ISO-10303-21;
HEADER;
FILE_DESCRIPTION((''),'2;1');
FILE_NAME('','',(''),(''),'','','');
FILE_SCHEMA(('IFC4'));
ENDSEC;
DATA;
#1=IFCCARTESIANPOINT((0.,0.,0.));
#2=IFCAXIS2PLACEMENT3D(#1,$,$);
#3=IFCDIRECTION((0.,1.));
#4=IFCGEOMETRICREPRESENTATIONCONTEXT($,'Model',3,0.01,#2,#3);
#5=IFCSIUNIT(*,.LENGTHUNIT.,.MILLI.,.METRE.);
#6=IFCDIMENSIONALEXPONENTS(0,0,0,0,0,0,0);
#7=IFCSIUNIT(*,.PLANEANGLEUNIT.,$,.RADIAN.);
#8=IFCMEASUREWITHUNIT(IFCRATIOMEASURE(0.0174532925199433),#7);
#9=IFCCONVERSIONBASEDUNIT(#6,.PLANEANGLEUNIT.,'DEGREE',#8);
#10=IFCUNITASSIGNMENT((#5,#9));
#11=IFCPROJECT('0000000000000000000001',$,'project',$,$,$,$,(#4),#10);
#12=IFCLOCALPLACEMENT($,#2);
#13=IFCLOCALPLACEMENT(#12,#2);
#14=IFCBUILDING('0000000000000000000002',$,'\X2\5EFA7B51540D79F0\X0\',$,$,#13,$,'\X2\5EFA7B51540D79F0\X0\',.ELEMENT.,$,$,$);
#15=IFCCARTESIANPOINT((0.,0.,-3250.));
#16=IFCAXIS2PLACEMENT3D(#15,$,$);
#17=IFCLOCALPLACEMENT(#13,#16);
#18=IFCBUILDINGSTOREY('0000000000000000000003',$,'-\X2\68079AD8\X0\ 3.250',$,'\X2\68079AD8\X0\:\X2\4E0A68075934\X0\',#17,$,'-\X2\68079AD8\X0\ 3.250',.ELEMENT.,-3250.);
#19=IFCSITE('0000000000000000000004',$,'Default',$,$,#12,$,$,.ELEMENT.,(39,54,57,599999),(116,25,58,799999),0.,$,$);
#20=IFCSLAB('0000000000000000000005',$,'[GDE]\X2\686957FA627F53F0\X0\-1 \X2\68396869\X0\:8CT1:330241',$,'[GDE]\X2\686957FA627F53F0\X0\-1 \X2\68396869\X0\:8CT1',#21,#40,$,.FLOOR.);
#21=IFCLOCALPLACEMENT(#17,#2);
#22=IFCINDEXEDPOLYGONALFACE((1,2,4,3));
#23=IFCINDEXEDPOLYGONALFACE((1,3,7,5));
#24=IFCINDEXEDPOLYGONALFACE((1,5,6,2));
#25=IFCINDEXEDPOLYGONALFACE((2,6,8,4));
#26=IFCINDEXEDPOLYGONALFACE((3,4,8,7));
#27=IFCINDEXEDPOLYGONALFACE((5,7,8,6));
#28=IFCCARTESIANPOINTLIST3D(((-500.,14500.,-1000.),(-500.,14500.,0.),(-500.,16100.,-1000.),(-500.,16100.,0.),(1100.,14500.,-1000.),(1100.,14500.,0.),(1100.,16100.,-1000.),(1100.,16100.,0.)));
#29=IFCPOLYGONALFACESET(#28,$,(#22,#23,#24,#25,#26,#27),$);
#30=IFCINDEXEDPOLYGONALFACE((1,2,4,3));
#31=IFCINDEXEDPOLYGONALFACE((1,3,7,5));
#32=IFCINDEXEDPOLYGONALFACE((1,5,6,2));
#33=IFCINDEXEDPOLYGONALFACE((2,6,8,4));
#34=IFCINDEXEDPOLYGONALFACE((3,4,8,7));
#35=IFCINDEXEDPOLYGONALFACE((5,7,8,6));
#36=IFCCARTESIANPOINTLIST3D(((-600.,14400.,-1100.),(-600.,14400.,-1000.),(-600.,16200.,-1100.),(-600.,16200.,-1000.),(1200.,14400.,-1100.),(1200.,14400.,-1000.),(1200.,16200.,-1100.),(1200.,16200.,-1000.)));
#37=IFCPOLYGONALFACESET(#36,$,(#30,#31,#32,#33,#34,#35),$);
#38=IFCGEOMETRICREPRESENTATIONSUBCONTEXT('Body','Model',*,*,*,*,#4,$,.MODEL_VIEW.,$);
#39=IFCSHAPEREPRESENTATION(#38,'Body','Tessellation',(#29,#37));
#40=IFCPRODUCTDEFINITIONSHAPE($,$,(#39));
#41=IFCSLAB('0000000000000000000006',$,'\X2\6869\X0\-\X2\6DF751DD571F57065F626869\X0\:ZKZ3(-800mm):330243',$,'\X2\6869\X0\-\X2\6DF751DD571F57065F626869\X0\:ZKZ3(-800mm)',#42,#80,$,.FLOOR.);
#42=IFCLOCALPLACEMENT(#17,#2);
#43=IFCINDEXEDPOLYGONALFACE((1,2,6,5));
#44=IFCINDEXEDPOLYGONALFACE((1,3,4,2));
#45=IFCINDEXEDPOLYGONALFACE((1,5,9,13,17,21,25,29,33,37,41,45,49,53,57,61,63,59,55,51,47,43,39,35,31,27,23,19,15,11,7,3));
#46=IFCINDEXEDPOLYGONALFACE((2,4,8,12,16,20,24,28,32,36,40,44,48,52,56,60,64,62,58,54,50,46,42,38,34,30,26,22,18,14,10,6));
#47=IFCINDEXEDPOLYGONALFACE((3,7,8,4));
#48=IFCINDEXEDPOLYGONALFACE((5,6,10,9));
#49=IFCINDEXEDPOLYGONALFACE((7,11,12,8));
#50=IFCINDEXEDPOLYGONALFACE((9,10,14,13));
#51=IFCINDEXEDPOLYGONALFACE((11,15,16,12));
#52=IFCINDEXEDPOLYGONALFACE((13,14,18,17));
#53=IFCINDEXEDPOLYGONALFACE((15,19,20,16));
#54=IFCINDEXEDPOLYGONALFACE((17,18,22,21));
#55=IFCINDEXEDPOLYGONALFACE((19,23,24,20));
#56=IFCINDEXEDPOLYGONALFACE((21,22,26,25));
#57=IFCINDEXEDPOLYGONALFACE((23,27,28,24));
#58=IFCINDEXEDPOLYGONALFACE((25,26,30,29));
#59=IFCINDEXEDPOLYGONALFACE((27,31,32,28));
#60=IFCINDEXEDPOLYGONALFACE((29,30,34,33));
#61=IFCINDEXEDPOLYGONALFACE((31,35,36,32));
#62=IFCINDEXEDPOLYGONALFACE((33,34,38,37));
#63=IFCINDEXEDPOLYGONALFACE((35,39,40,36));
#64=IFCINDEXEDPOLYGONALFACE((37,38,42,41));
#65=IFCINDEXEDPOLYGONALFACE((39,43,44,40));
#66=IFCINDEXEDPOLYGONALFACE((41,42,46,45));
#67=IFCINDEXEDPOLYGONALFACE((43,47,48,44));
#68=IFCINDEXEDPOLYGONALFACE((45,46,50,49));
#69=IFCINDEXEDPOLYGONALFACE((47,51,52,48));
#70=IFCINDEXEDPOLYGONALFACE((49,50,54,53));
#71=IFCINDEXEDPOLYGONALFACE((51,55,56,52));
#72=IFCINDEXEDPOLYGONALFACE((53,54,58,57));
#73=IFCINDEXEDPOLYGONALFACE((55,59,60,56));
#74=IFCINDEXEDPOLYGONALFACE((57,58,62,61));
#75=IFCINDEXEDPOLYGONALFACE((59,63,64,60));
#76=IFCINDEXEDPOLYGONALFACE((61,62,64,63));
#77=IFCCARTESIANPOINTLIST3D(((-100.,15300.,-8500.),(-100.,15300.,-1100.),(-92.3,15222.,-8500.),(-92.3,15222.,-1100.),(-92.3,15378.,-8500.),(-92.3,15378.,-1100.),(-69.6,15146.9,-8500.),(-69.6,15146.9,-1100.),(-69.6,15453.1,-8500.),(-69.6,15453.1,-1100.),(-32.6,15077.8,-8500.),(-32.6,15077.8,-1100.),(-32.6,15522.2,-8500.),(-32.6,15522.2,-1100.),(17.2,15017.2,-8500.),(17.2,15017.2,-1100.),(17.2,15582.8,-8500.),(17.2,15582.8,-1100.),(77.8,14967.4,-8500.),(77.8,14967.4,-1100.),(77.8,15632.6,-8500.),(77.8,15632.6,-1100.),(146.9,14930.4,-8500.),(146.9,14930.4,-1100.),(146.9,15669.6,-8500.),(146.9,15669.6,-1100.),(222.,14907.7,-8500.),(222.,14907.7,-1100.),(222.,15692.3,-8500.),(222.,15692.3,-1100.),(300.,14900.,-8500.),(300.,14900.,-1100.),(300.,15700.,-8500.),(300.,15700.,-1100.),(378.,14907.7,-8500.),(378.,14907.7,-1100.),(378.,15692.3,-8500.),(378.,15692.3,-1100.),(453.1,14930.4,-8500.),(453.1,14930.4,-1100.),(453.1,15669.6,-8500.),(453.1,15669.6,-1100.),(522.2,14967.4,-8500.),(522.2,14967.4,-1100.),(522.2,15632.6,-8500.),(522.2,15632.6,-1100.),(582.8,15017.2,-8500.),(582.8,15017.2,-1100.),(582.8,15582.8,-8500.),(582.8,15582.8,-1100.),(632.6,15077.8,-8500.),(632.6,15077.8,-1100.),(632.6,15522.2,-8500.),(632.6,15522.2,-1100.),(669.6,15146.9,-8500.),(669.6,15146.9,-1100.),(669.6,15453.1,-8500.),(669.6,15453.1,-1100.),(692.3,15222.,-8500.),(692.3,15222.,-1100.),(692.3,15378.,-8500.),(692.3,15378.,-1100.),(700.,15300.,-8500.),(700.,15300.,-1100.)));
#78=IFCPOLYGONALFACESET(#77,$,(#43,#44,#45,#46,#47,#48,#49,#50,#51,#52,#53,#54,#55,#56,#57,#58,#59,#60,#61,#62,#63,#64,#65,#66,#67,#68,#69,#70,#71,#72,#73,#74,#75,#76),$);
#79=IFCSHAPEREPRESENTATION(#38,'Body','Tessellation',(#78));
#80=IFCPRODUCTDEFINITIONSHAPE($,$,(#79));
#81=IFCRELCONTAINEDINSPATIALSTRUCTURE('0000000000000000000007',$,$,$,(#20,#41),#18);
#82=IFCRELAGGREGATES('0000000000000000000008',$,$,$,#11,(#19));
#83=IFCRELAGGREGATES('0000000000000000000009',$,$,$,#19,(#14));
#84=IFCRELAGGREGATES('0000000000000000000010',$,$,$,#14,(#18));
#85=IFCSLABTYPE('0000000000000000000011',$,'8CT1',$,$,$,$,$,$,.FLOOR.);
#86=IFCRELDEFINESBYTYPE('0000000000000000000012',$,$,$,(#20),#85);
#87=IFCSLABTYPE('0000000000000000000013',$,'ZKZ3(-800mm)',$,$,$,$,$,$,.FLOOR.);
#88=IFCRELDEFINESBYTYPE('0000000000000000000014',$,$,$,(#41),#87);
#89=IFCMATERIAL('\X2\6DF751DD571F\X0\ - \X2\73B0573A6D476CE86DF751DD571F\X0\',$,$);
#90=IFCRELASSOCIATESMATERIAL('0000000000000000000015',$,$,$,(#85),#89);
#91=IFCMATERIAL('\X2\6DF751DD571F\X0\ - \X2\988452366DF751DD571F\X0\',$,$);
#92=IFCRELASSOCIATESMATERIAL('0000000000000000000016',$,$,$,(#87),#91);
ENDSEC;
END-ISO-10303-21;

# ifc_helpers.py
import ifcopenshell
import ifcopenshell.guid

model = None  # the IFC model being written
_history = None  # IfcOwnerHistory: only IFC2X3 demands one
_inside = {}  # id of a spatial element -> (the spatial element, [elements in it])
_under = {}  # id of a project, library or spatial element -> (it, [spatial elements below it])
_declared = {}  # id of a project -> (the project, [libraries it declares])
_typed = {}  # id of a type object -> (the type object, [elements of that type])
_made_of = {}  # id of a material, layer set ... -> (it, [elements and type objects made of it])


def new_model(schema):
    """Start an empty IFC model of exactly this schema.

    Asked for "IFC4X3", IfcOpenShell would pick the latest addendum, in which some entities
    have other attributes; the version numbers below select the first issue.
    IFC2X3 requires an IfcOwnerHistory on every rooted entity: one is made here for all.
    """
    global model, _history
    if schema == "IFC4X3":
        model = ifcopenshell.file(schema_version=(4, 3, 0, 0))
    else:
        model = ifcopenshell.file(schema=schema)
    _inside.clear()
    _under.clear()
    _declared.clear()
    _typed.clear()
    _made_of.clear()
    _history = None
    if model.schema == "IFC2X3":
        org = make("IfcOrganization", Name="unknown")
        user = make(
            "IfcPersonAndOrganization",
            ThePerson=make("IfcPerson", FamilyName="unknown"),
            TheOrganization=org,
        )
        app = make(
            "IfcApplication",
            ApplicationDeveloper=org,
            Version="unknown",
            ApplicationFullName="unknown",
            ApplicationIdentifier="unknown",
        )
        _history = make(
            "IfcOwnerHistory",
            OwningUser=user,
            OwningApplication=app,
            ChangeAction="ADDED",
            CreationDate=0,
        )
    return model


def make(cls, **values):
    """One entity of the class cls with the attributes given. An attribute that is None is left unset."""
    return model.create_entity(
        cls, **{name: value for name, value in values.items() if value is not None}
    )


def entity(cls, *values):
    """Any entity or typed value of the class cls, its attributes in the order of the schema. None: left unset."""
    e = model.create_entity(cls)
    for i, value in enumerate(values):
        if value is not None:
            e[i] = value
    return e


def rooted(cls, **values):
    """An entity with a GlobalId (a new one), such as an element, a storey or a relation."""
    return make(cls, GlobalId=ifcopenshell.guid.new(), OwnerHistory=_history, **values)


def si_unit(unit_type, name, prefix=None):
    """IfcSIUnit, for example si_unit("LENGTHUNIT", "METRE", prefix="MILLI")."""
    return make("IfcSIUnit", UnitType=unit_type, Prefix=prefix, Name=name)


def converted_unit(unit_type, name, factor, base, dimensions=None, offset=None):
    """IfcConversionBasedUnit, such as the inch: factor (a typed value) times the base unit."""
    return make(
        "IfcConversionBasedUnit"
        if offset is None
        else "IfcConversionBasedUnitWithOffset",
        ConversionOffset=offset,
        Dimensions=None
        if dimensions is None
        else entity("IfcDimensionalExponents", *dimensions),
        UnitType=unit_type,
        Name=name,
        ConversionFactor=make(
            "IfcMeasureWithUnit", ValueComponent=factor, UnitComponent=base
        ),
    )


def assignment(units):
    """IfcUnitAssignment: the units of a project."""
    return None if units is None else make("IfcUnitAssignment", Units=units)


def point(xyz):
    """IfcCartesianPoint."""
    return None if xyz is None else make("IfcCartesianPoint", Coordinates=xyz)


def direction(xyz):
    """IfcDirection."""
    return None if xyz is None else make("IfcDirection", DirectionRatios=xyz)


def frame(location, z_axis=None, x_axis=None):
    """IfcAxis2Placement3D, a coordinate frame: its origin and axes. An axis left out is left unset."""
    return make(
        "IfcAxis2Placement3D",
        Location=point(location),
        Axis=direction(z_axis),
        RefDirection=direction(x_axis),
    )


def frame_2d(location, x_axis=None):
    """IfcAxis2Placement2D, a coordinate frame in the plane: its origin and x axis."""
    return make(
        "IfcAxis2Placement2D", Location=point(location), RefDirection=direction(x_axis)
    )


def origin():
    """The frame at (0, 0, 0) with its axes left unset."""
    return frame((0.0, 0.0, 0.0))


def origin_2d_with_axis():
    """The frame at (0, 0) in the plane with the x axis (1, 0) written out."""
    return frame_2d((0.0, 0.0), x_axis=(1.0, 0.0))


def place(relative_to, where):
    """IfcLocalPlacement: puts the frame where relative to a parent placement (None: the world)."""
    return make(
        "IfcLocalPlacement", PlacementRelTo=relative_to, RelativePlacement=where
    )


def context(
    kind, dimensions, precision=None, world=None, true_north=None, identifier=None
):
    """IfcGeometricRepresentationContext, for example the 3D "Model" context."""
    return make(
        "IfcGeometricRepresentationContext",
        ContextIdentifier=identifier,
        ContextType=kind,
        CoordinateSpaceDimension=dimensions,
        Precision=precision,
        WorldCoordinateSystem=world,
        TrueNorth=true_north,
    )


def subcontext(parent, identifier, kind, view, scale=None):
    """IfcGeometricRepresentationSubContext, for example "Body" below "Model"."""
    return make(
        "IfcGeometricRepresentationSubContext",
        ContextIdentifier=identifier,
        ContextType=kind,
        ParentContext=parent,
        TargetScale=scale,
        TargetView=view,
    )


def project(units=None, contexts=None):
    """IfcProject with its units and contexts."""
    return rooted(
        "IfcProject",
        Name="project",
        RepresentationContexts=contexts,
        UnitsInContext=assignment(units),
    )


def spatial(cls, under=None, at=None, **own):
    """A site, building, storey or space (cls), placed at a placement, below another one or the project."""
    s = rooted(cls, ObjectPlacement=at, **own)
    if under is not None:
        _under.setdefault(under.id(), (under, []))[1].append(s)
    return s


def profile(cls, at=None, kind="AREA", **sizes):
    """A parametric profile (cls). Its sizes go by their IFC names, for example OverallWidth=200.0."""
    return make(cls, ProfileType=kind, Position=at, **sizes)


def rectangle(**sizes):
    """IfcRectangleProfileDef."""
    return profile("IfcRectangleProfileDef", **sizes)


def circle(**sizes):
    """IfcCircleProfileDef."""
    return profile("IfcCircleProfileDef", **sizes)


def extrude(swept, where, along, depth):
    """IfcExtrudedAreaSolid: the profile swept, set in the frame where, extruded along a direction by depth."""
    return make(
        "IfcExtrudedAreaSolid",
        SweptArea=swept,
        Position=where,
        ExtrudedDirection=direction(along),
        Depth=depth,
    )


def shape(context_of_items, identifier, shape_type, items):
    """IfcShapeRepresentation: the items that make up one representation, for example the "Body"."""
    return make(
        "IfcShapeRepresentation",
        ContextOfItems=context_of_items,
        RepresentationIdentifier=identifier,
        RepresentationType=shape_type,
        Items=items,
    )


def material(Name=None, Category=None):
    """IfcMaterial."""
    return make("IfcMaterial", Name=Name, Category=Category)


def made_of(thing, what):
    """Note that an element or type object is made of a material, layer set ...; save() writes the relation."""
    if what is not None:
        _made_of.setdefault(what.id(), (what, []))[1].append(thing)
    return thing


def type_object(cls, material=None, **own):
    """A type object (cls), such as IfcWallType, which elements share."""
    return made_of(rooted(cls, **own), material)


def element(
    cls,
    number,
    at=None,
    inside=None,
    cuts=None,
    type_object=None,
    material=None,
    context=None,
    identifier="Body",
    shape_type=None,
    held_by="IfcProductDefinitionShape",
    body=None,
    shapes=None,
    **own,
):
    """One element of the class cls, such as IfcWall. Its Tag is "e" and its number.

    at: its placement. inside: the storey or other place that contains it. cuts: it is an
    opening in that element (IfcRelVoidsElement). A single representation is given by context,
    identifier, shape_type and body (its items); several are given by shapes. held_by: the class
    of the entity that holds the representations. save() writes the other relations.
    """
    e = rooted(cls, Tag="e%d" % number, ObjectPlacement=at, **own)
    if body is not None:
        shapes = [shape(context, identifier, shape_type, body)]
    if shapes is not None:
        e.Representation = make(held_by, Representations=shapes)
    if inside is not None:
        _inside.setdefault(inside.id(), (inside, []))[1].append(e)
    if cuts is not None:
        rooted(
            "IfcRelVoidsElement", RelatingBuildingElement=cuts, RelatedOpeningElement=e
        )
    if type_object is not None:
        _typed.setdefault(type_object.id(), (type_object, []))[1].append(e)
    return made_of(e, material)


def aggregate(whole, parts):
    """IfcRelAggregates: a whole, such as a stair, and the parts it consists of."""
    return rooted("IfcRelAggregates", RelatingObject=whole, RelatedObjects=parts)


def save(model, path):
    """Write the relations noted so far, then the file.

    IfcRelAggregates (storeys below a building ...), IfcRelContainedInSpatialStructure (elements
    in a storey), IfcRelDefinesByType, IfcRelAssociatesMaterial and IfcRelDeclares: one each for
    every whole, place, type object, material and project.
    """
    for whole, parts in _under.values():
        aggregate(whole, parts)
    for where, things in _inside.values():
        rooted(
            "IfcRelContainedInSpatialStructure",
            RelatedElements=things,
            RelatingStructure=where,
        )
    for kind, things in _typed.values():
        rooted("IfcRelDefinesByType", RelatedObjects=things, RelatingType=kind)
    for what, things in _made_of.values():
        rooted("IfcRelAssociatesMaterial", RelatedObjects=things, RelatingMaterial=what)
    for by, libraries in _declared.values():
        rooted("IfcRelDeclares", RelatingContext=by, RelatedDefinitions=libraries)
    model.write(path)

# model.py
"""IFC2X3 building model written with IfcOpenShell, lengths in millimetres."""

from ifc_helpers import new_model, entity, si_unit, converted_unit, direction, frame, frame_2d, origin, origin_2d_with_axis, place, context, subcontext, project, spatial, rectangle, circle, extrude, material, type_object, element, save


model = new_model("IFC2X3")

# Units and contexts
model_context = context("Model", 3, precision=0.01, world=origin(), true_north=direction((0.0, 1.0)))
body_context = subcontext(model_context, "Body", "Model", "MODEL_VIEW")
ifc_project = project(units=[si_unit("LENGTHUNIT", "METRE", prefix="MILLI"), converted_unit("PLANEANGLEUNIT", "DEGREE", entity("IfcRatioMeasure", 0.0174532925199433), si_unit("PLANEANGLEUNIT", "RADIAN"), dimensions=[0, 0, 0, 0, 0, 0, 0])], contexts=[model_context])

# Site, building, storey
site_placement = place(None, origin())
site = spatial("IfcSite", under=ifc_project, at=site_placement, Name="Default", CompositionType="ELEMENT", RefLatitude=(39, 54, 57, 599999), RefLongitude=(116, 25, 58, 799999), RefElevation=0.0)
building_placement = place(site_placement, origin())
building = spatial("IfcBuilding", under=site, at=building_placement, Name="建筑名称", LongName="建筑名称", CompositionType="ELEMENT")
storey_placement = place(building_placement, frame((0.0, 0.0, -3250.0)))
storey = spatial("IfcBuildingStorey", under=building, at=storey_placement, Name="-标高 3.250", ObjectType="标高:上标头", LongName="-标高 3.250", CompositionType="ELEMENT", Elevation=-3250.0)

# Slabs
ifc_material_1 = material(Name="混凝土 - 现场浇注混凝土")
ifc_material_2 = material(Name="混凝土 - 预制混凝土")
slab_type_1 = type_object("IfcSlabType", Name="8CT1", PredefinedType="FLOOR", material=ifc_material_1)
slab_1_placement = place(storey_placement, origin())
element("IfcSlab", 1, at=slab_1_placement, inside=storey, type_object=slab_type_1, Name="[GDE]桩基承台-1 根桩:8CT1:330241", ObjectType="[GDE]桩基承台-1 根桩:8CT1", PredefinedType="FLOOR", context=body_context, shape_type="SweptSolid", body=[
    extrude(rectangle(XDim=1600.0, YDim=1600.0, at=origin_2d_with_axis()), frame((300.0, 15300.0, -1000.0), z_axis=(0.0, 0.0, 1.0), x_axis=(-1.0, 0.0, 0.0)), (0.0, 0.0, 1.0), 1000.0),
    extrude(rectangle(XDim=1800.0, YDim=1800.0, at=frame_2d((0.0, 0.0), x_axis=(1.0, 0.0))), frame((300.0, 15300.0, -1100.0), z_axis=(0.0, 0.0, 1.0), x_axis=(-1.0, 0.0, 0.0)), (0.0, 0.0, 1.0), 100.0),
])
slab_type_2 = type_object("IfcSlabType", Name="ZKZ3(-800mm)", PredefinedType="FLOOR", material=ifc_material_2)
slab_2_placement = place(storey_placement, origin())
element("IfcSlab", 2, at=slab_2_placement, inside=storey, type_object=slab_type_2, Name="桩-混凝土圆形桩:ZKZ3(-800mm):330243", ObjectType="桩-混凝土圆形桩:ZKZ3(-800mm)", PredefinedType="FLOOR", context=body_context, shape_type="SweptSolid", body=[
    extrude(circle(Radius=400.0, at=frame_2d((0.0, 0.0), x_axis=(1.0, 0.0))), frame((300.0, 15300.0, -8500.0)), (0.0, 0.0, 1.0), 7400.0),
])

save(model, "model.ifc")
